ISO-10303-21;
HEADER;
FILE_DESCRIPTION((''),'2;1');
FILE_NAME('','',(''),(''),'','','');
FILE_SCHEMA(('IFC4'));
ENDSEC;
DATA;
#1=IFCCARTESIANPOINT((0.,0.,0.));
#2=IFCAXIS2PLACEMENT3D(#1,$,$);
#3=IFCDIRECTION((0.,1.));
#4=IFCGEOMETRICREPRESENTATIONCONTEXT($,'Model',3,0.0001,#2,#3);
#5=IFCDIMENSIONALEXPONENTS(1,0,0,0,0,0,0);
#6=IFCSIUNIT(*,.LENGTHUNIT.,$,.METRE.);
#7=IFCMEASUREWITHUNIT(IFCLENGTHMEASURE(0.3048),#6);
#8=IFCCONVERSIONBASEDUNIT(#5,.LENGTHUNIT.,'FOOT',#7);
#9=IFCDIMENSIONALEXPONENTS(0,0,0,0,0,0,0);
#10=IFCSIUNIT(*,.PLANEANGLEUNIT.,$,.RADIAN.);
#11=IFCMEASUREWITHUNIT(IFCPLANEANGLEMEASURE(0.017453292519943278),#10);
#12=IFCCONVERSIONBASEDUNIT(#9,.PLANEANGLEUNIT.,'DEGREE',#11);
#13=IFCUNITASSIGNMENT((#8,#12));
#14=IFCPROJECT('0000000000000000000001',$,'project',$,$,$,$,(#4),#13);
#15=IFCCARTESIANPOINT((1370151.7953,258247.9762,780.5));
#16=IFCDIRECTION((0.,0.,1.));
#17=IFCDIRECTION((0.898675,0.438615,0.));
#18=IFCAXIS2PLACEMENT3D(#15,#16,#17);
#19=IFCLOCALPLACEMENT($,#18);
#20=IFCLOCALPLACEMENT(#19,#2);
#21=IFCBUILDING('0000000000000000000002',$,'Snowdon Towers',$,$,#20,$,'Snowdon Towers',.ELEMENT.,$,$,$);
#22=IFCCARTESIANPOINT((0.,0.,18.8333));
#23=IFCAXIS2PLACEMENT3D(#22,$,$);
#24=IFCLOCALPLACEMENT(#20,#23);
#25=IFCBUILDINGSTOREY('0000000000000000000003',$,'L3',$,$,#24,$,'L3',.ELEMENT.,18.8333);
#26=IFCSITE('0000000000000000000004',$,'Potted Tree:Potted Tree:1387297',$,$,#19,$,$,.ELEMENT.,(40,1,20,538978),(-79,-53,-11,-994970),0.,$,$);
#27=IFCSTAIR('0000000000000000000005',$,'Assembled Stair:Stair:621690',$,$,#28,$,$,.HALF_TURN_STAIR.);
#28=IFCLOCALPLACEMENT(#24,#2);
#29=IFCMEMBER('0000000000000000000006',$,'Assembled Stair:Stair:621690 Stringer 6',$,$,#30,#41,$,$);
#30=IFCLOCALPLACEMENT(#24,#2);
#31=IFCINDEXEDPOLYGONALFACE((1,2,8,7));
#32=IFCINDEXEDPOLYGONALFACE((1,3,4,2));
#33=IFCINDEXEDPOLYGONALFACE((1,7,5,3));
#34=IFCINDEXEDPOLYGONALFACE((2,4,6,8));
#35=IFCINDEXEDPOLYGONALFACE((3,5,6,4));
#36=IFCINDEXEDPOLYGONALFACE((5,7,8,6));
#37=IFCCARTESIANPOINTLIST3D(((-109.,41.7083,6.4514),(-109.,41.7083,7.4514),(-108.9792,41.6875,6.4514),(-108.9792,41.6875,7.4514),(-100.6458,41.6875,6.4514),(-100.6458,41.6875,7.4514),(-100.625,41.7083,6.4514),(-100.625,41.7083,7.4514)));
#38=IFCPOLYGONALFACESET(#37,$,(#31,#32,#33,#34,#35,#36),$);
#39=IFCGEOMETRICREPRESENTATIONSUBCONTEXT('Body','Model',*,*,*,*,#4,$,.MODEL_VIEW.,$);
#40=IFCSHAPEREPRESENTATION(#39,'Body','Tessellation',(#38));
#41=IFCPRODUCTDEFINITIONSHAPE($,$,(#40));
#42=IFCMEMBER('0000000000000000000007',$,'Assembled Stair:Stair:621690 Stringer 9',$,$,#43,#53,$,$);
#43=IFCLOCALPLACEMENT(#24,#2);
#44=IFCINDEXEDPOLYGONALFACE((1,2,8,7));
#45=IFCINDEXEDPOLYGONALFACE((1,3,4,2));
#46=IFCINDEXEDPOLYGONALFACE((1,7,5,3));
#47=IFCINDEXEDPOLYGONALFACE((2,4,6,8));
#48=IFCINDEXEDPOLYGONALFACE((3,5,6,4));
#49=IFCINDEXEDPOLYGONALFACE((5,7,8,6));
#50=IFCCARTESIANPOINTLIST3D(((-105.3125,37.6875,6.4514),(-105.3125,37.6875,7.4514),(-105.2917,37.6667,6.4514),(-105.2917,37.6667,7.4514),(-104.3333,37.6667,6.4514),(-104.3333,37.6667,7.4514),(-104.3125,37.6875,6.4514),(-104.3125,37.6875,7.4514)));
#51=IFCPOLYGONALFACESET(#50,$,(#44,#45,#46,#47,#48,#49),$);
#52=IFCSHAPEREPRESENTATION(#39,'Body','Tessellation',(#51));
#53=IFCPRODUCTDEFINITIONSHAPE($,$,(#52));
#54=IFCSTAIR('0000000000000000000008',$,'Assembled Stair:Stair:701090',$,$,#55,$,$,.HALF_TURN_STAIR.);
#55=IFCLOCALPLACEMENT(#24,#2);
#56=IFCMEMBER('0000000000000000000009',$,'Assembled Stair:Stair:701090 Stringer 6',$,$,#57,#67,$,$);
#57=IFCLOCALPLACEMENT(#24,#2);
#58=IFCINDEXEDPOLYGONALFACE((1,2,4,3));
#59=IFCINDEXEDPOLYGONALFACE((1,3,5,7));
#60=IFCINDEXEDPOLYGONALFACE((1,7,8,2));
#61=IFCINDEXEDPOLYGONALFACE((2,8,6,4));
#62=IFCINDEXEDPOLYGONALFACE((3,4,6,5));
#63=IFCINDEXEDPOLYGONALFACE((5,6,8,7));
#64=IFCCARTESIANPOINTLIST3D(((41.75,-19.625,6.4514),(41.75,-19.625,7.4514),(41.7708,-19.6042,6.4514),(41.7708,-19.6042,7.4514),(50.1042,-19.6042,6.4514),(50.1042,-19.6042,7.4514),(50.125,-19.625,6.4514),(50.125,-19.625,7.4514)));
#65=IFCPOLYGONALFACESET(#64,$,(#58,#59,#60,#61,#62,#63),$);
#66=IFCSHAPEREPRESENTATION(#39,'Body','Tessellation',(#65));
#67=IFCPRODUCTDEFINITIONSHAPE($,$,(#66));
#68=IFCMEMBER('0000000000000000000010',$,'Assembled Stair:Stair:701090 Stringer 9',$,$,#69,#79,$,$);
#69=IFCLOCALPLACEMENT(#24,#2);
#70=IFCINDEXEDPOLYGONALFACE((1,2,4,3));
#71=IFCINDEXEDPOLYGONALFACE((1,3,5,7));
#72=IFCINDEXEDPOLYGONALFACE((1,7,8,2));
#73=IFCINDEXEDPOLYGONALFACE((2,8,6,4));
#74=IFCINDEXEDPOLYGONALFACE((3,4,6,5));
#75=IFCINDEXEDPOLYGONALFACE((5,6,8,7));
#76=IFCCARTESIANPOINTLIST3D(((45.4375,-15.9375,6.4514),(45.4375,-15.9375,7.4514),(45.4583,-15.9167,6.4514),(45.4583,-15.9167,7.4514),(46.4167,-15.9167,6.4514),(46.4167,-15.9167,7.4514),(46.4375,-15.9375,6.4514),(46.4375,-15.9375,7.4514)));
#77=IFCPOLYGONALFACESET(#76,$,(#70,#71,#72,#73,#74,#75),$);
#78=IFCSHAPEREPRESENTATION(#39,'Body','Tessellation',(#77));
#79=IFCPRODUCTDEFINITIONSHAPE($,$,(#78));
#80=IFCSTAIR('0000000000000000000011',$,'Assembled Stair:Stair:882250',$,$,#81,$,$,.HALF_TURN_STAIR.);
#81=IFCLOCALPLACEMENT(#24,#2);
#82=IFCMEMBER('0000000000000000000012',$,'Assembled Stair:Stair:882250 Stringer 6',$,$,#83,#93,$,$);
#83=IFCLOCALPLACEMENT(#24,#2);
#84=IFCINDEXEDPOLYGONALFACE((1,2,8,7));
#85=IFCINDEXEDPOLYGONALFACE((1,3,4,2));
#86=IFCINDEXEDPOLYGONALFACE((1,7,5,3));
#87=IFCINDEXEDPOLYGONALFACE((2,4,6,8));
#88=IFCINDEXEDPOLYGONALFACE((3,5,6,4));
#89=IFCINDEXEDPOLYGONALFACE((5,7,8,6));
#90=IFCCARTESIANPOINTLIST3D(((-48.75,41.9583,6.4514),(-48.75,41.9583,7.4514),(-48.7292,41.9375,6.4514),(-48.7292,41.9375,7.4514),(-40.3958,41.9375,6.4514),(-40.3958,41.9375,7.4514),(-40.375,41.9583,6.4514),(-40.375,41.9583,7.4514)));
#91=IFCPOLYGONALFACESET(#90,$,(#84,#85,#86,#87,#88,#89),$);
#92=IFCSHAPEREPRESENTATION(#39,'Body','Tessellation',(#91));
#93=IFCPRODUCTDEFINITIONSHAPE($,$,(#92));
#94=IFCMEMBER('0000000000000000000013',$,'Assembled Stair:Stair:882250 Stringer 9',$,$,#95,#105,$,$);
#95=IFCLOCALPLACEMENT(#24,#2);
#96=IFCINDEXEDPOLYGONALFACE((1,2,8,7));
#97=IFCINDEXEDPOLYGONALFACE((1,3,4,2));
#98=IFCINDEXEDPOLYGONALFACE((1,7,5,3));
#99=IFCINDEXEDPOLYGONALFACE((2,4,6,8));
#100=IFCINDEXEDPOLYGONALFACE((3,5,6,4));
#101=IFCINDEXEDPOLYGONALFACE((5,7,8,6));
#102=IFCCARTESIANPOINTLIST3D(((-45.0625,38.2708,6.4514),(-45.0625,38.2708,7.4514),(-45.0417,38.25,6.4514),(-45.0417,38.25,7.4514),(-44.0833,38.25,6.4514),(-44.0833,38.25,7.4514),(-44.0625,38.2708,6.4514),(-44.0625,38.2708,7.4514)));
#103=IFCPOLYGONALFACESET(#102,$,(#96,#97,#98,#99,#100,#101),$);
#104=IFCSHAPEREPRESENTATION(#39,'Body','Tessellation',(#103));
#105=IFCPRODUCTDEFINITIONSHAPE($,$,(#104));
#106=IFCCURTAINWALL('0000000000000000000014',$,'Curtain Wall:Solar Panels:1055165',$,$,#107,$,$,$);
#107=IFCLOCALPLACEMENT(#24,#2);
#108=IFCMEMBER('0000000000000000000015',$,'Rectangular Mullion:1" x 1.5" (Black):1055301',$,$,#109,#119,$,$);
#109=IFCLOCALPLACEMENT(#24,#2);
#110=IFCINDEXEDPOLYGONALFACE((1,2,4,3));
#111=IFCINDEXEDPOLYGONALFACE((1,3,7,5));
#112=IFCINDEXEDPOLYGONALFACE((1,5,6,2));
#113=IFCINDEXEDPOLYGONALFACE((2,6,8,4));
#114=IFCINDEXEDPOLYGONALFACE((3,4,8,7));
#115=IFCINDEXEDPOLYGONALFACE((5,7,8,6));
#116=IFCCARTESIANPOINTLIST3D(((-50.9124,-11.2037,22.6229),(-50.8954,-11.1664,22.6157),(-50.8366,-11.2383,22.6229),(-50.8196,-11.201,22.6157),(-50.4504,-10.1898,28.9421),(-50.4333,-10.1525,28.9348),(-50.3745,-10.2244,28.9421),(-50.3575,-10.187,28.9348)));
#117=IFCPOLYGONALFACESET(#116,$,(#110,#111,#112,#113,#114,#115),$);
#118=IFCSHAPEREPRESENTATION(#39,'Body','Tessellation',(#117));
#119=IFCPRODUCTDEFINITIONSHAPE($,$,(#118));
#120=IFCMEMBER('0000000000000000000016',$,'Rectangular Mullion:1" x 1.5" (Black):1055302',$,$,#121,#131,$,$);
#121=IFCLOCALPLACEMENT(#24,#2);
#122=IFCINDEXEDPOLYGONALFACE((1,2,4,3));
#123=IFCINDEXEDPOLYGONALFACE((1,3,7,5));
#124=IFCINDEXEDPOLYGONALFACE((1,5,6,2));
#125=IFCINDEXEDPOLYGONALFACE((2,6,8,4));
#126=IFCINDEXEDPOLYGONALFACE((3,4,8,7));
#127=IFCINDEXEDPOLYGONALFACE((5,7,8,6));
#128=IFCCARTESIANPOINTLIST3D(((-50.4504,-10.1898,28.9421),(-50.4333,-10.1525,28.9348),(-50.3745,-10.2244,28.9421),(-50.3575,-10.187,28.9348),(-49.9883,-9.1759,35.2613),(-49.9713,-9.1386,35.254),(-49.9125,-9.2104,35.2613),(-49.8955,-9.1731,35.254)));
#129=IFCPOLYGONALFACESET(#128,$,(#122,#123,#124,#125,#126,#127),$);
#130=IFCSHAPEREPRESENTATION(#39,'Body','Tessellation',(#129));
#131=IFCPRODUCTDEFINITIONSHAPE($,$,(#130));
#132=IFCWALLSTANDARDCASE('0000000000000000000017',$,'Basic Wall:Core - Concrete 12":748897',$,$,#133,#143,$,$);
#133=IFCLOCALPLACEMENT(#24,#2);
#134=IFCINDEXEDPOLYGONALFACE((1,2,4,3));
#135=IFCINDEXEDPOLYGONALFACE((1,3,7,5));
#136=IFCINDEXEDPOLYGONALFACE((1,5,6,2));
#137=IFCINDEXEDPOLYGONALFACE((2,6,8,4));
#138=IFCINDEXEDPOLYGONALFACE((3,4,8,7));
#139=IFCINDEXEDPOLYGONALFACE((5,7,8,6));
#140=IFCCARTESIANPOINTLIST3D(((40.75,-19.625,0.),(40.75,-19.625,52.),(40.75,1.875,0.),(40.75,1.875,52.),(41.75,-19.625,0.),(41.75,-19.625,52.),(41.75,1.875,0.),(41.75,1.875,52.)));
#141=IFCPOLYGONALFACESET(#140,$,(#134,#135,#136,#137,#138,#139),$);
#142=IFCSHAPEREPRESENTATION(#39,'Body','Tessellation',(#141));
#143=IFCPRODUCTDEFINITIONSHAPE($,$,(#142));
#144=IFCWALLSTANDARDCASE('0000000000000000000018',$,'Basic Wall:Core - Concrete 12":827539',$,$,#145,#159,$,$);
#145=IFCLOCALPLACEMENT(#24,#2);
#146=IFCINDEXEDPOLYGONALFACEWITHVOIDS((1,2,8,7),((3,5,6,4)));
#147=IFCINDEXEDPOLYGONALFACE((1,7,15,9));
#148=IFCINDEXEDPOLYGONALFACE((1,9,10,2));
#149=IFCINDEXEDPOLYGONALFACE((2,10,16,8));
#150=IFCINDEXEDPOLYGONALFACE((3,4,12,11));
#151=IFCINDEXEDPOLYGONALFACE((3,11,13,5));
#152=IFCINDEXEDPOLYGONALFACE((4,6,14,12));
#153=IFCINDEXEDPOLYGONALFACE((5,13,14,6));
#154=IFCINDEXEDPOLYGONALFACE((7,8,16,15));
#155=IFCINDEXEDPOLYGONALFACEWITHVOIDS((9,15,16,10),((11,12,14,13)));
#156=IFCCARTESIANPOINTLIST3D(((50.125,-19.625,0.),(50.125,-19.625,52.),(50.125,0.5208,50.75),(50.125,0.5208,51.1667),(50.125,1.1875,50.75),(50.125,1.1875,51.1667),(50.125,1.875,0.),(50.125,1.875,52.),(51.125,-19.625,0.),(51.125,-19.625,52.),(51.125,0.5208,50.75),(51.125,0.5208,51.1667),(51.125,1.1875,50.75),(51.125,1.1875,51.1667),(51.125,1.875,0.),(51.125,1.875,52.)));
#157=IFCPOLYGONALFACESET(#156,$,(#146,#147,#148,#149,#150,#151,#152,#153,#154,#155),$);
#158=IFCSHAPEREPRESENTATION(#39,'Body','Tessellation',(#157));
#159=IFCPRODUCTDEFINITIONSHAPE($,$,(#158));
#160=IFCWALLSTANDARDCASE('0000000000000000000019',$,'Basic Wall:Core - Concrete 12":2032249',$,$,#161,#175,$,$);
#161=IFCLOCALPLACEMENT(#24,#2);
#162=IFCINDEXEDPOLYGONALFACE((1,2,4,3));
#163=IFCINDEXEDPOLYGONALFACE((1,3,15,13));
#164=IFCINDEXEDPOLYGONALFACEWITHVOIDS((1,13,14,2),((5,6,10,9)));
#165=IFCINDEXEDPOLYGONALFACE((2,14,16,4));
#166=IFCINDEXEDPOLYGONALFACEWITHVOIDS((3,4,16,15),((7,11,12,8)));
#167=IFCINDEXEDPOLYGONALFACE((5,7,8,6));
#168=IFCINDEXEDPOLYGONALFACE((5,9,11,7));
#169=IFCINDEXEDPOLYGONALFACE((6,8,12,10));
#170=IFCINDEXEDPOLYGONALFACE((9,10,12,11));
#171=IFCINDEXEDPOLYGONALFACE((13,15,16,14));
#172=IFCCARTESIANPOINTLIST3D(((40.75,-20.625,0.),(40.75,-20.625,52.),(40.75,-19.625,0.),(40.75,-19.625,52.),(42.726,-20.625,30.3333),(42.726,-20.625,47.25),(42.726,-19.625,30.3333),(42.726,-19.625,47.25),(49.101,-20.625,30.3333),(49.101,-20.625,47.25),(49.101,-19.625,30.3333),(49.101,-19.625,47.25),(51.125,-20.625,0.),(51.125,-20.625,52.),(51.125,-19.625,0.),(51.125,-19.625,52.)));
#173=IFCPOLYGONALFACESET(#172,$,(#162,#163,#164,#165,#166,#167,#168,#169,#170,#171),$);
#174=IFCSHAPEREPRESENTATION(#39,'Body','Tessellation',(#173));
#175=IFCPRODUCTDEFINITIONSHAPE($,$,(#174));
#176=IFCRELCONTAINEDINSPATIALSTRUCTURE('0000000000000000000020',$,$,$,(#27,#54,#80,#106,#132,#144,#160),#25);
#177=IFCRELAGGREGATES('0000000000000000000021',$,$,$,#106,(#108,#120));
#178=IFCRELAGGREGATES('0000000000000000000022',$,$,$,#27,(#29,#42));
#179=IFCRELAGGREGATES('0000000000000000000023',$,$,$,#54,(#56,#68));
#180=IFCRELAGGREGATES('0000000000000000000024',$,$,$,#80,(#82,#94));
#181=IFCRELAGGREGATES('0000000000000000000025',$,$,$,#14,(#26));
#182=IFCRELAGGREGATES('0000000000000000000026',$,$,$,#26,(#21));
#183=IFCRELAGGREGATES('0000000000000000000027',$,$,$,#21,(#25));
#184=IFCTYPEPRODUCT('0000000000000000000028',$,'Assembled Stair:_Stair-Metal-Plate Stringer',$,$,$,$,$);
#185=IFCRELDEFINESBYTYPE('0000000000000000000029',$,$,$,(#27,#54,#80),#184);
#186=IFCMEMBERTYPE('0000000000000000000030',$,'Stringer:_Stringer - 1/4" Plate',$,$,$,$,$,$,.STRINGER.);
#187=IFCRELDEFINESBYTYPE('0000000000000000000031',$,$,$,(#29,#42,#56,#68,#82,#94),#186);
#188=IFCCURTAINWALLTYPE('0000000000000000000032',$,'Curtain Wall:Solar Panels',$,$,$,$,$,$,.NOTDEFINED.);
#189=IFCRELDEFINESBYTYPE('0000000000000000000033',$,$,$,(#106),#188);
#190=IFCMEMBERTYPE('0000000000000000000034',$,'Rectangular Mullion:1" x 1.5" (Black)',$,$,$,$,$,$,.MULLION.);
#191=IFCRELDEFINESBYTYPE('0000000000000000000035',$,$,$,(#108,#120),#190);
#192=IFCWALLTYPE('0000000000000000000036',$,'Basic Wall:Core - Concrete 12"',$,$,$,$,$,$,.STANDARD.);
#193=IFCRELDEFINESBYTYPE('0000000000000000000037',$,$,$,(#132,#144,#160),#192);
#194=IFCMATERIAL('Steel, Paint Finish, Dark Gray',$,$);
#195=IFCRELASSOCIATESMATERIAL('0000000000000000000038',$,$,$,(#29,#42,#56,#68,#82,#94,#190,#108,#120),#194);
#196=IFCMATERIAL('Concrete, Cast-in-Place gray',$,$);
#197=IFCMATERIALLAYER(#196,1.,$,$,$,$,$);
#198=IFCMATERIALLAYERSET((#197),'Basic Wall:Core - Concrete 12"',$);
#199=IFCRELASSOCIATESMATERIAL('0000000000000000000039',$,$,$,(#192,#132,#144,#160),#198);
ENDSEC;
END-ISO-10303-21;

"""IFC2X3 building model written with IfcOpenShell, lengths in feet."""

from ifc_helpers import new_model, entity, si_unit, converted_unit, direction, frame, frame_2d, origin, origin_2d_with_axis, place, context, subcontext, project, spatial, polyline, rectangle, outline, extrude, source, transform, mapped, material, layer, layer_set, layer_usage, type_object, type_shapes, element, aggregate, save


model = new_model("IFC2X3")

# Units and contexts
model_context = context("Model", 3, precision=0.0001, world=origin(), true_north=direction((0.0, 1.0)))
body_context = subcontext(model_context, "Body", "Model", "MODEL_VIEW")
ifc_project = project(units=[converted_unit("LENGTHUNIT", "FOOT", entity("IfcLengthMeasure", 0.3048), si_unit("LENGTHUNIT", "METRE"), dimensions=[1, 0, 0, 0, 0, 0, 0]), converted_unit("PLANEANGLEUNIT", "DEGREE", entity("IfcPlaneAngleMeasure", 0.017453292519943278), si_unit("PLANEANGLEUNIT", "RADIAN"), dimensions=[0, 0, 0, 0, 0, 0, 0])], contexts=[model_context])

# Site, building, storey
site_placement = place(None, frame((1370151.7953, 258247.9762, 780.5), z_axis=(0.0, 0.0, 1.0), x_axis=(0.898675, 0.438615, 0.0)))
site = spatial("IfcSite", under=ifc_project, at=site_placement, Name="Potted Tree:Potted Tree:1387297", CompositionType="ELEMENT", RefLatitude=(40, 1, 20, 538978), RefLongitude=(-79, -53, -11, -994970), RefElevation=0.0)
building_placement = place(site_placement, origin())
building = spatial("IfcBuilding", under=site, at=building_placement, Name="Snowdon Towers", LongName="Snowdon Towers", CompositionType="ELEMENT")
storey_placement = place(building_placement, frame((0.0, 0.0, 18.8333)))
storey = spatial("IfcBuildingStorey", under=building, at=storey_placement, Name="L3", LongName="L3", CompositionType="ELEMENT", Elevation=18.8333)

# Stairs, members
type_product = type_object("IfcTypeProduct", Name="Assembled Stair:_Stair-Metal-Plate Stringer")
stair_1_placement = place(storey_placement, origin())
stair_1 = element("IfcStair", 1, at=stair_1_placement, inside=storey, type_object=type_product, Name="Assembled Stair:Stair:621690", ShapeType="HALF_TURN_STAIR")
ifc_material_1 = material(Name="Steel, Paint Finish, Dark Gray")
member_type_1 = type_object("IfcMemberType", Name="Stringer:_Stringer - 1/4\" Plate", PredefinedType="STRINGER")
member_1_placement = place(stair_1_placement, origin())
member_1 = element("IfcMember", 2, at=member_1_placement, type_object=member_type_1, material=ifc_material_1, Name="Assembled Stair:Stair:621690 Stringer 6", context=body_context, shape_type="SweptSolid", body=[
    extrude(outline(polyline([(-4.1875, -0.0104), (4.1875, -0.0104), (4.1667, 0.0104), (-4.1667, 0.0104), (-4.1875, -0.0104)])), frame((-104.8125, 41.6979, 6.4514), z_axis=(0.0, 0.0, 1.0), x_axis=(-1.0, 0.0, 0.0)), (0.0, 0.0, 1.0), 1.0),
])
member_2_placement = place(stair_1_placement, origin())
member_2 = element("IfcMember", 3, at=member_2_placement, type_object=member_type_1, material=ifc_material_1, Name="Assembled Stair:Stair:621690 Stringer 9", context=body_context, shape_type="SweptSolid", body=[
    extrude(outline(polyline([(-0.4792, -0.0104), (0.4792, -0.0104), (0.5, 0.0104), (-0.5, 0.0104), (-0.4792, -0.0104)])), frame((-104.8125, 37.6771, 6.4514)), (0.0, 0.0, 1.0), 1.0),
])
stair_2_placement = place(storey_placement, origin())
stair_2 = element("IfcStair", 4, at=stair_2_placement, inside=storey, type_object=type_product, Name="Assembled Stair:Stair:701090", ShapeType="HALF_TURN_STAIR")
member_3_placement = place(stair_2_placement, origin())
member_3 = element("IfcMember", 5, at=member_3_placement, type_object=member_type_1, material=ifc_material_1, Name="Assembled Stair:Stair:701090 Stringer 6", context=body_context, shape_type="SweptSolid", body=[
    extrude(outline(polyline([(-4.1875, -0.0104), (4.1875, -0.0104), (4.1667, 0.0104), (-4.1667, 0.0104), (-4.1875, -0.0104)])), frame((45.9375, -19.6146, 6.4514)), (0.0, 0.0, 1.0), 1.0),
])
member_4_placement = place(stair_2_placement, origin())
member_4 = element("IfcMember", 6, at=member_4_placement, type_object=member_type_1, material=ifc_material_1, Name="Assembled Stair:Stair:701090 Stringer 9", context=body_context, shape_type="SweptSolid", body=[
    extrude(outline(polyline([(-0.4792, -0.0104), (0.4792, -0.0104), (0.5, 0.0104), (-0.5, 0.0104), (-0.4792, -0.0104)])), frame((45.9375, -15.9271, 6.4514), z_axis=(0.0, 0.0, 1.0), x_axis=(-1.0, 0.0, 0.0)), (0.0, 0.0, 1.0), 1.0),
])
stair_3_placement = place(storey_placement, origin())
stair_3 = element("IfcStair", 7, at=stair_3_placement, inside=storey, type_object=type_product, Name="Assembled Stair:Stair:882250", ShapeType="HALF_TURN_STAIR")
member_5_placement = place(stair_3_placement, origin())
member_5 = element("IfcMember", 8, at=member_5_placement, type_object=member_type_1, material=ifc_material_1, Name="Assembled Stair:Stair:882250 Stringer 6", context=body_context, shape_type="SweptSolid", body=[
    extrude(outline(polyline([(-4.1875, -0.0104), (4.1875, -0.0104), (4.1667, 0.0104), (-4.1667, 0.0104), (-4.1875, -0.0104)])), frame((-44.5625, 41.9479, 6.4514), z_axis=(0.0, 0.0, 1.0), x_axis=(-1.0, 0.0, 0.0)), (0.0, 0.0, 1.0), 1.0),
])
member_6_placement = place(stair_3_placement, origin())
member_6 = element("IfcMember", 9, at=member_6_placement, type_object=member_type_1, material=ifc_material_1, Name="Assembled Stair:Stair:882250 Stringer 9", context=body_context, shape_type="SweptSolid", body=[
    extrude(outline(polyline([(-0.4792, -0.0104), (0.4792, -0.0104), (0.5, 0.0104), (-0.5, 0.0104), (-0.4792, -0.0104)])), frame((-44.5625, 38.2604, 6.4514)), (0.0, 0.0, 1.0), 1.0),
])

# Curtain wall, members
curtain_wall_type = type_object("IfcCurtainWallType", Name="Curtain Wall:Solar Panels", PredefinedType="NOTDEFINED")
curtain_wall_placement = place(storey_placement, frame((0.0, 0.0, -18.8333)))
curtain_wall = element("IfcCurtainWall", 10, at=curtain_wall_placement, inside=storey, type_object=curtain_wall_type, Name="Curtain Wall:Solar Panels:1055165")
member_type_2 = type_object("IfcMemberType", Name="Rectangular Mullion:1\" x 1.5\" (Black)", PredefinedType="MULLION", material=ifc_material_1)
shared_shape = source(origin(), body_context, "Body", "SweptSolid", [
    extrude(rectangle(XDim=0.0833, YDim=0.0417, at=origin_2d_with_axis()), frame((-0.0417, 0.0208, -6.4167), z_axis=(0.0, 0.0, 1.0), x_axis=(-1.0, 0.0, 0.0)), (0.0, 0.0, 1.0), 6.4167),
])
type_shapes(member_type_2, [shared_shape])
member_7_placement = place(curtain_wall_placement, frame((-50.8196, -11.201, 41.449), z_axis=(-0.072007, -0.158015, -0.984808), x_axis=(0.909972, -0.414671, 0.0)))
member_7 = element("IfcMember", 11, at=member_7_placement, type_object=member_type_2, material=ifc_material_1, Name="Rectangular Mullion:1\" x 1.5\" (Black):1055301", context=body_context, shape_type="MappedRepresentation", body=[
    mapped(shared_shape, transform((0.0, 0.0, 0.0), scale=1.0)),
])
member_8_placement = place(curtain_wall_placement, frame((-50.3575, -10.187, 47.7682), z_axis=(-0.072007, -0.158015, -0.984808), x_axis=(0.909972, -0.414671, 0.0)))
member_8 = element("IfcMember", 12, at=member_8_placement, type_object=member_type_2, material=ifc_material_1, Name="Rectangular Mullion:1\" x 1.5\" (Black):1055302", context=body_context, shape_type="MappedRepresentation", body=[
    mapped(shared_shape, transform((0.0, 0.0, 0.0), scale=1.0)),
])
aggregate(curtain_wall, [member_7, member_8])

# Wall
ifc_material_2 = material(Name="Concrete, Cast-in-Place gray")
ifc_layer_1 = layer(ifc_material_2, 1.0)
ifc_layer_set_1 = layer_set([ifc_layer_1], Name="Basic Wall:Core - Concrete 12\"")
ifc_layer_usage_1 = layer_usage(ifc_layer_set_1, "AXIS2", "POSITIVE", -0.5)
wall_type_1 = type_object("IfcWallType", Name="Basic Wall:Core - Concrete 12\"", PredefinedType="STANDARD", material=ifc_layer_set_1)
wall_1_placement = place(storey_placement, frame((41.25, 1.875, 0.0), z_axis=(0.0, 0.0, 1.0), x_axis=(0.0, -1.0, 0.0)))
element("IfcWallStandardCase", 13, at=wall_1_placement, inside=storey, type_object=wall_type_1, material=ifc_layer_usage_1, Name="Basic Wall:Core - Concrete 12\":748897", context=body_context, shape_type="SweptSolid", body=[
    extrude(rectangle(XDim=21.5, YDim=1.0, at=frame_2d((10.75, 0.0), x_axis=(-1.0, 0.0))), origin(), (0.0, 0.0, 1.0), 52.0),
])

# Walls, openings
ifc_layer_usage_2 = layer_usage(ifc_layer_set_1, "AXIS2", "POSITIVE", -0.5)
wall_2_placement = place(storey_placement, frame((50.625, -19.625, 0.0), z_axis=(0.0, 0.0, 1.0), x_axis=(0.0, 1.0, 0.0)))
wall_2 = element("IfcWallStandardCase", 14, at=wall_2_placement, inside=storey, type_object=wall_type_1, material=ifc_layer_usage_2, Name="Basic Wall:Core - Concrete 12\":827539", context=body_context, shape_type="SweptSolid", body=[
    extrude(rectangle(XDim=21.5, YDim=1.0, at=frame_2d((10.75, 0.0), x_axis=(-1.0, 0.0))), origin(), (0.0, 0.0, 1.0), 52.0),
])
opening_1_placement = place(wall_2_placement, origin())
element("IfcOpeningElement", 15, at=opening_1_placement, cuts=wall_2, ObjectType="Opening", context=body_context, shape_type="SweptSolid", body=[
    extrude(rectangle(XDim=0.4167, YDim=0.6667, at=frame_2d((0.0, 0.0), x_axis=(1.0, 0.0))), frame((20.4792, -0.9479, 50.9583), z_axis=(0.0, 1.0, 0.0), x_axis=(0.0, 0.0, -1.0)), (0.0, 0.0, 1.0), 2.4479),
])
ifc_layer_usage_3 = layer_usage(ifc_layer_set_1, "AXIS2", "NEGATIVE", 0.5)
wall_3_placement = place(storey_placement, frame((51.125, -20.125, 0.0), z_axis=(0.0, 0.0, 1.0), x_axis=(-1.0, 0.0, 0.0)))
wall_3 = element("IfcWallStandardCase", 16, at=wall_3_placement, inside=storey, type_object=wall_type_1, material=ifc_layer_usage_3, Name="Basic Wall:Core - Concrete 12\":2032249", context=body_context, shape_type="SweptSolid", body=[
    extrude(rectangle(XDim=10.375, YDim=1.0, at=frame_2d((5.1875, 0.0), x_axis=(-1.0, 0.0))), origin(), (0.0, 0.0, 1.0), 52.0),
])
opening_2_placement = place(wall_3_placement, origin())
element("IfcOpeningElement", 17, at=opening_2_placement, cuts=wall_3, ObjectType="Opening", context=body_context, shape_type="SweptSolid", body=[
    extrude(rectangle(XDim=16.9167, YDim=6.375, at=frame_2d((0.0, 0.0), x_axis=(0.0, 1.0))), frame((5.2115, -1.0, 38.7917), z_axis=(0.0, 1.0, 0.0), x_axis=(-1.0, 0.0, 0.0)), (0.0, 0.0, 1.0), 2.0),
])

aggregate(stair_1, [member_1, member_2])
aggregate(stair_2, [member_3, member_4])
aggregate(stair_3, [member_5, member_6])

save(model, "model.ifc")
